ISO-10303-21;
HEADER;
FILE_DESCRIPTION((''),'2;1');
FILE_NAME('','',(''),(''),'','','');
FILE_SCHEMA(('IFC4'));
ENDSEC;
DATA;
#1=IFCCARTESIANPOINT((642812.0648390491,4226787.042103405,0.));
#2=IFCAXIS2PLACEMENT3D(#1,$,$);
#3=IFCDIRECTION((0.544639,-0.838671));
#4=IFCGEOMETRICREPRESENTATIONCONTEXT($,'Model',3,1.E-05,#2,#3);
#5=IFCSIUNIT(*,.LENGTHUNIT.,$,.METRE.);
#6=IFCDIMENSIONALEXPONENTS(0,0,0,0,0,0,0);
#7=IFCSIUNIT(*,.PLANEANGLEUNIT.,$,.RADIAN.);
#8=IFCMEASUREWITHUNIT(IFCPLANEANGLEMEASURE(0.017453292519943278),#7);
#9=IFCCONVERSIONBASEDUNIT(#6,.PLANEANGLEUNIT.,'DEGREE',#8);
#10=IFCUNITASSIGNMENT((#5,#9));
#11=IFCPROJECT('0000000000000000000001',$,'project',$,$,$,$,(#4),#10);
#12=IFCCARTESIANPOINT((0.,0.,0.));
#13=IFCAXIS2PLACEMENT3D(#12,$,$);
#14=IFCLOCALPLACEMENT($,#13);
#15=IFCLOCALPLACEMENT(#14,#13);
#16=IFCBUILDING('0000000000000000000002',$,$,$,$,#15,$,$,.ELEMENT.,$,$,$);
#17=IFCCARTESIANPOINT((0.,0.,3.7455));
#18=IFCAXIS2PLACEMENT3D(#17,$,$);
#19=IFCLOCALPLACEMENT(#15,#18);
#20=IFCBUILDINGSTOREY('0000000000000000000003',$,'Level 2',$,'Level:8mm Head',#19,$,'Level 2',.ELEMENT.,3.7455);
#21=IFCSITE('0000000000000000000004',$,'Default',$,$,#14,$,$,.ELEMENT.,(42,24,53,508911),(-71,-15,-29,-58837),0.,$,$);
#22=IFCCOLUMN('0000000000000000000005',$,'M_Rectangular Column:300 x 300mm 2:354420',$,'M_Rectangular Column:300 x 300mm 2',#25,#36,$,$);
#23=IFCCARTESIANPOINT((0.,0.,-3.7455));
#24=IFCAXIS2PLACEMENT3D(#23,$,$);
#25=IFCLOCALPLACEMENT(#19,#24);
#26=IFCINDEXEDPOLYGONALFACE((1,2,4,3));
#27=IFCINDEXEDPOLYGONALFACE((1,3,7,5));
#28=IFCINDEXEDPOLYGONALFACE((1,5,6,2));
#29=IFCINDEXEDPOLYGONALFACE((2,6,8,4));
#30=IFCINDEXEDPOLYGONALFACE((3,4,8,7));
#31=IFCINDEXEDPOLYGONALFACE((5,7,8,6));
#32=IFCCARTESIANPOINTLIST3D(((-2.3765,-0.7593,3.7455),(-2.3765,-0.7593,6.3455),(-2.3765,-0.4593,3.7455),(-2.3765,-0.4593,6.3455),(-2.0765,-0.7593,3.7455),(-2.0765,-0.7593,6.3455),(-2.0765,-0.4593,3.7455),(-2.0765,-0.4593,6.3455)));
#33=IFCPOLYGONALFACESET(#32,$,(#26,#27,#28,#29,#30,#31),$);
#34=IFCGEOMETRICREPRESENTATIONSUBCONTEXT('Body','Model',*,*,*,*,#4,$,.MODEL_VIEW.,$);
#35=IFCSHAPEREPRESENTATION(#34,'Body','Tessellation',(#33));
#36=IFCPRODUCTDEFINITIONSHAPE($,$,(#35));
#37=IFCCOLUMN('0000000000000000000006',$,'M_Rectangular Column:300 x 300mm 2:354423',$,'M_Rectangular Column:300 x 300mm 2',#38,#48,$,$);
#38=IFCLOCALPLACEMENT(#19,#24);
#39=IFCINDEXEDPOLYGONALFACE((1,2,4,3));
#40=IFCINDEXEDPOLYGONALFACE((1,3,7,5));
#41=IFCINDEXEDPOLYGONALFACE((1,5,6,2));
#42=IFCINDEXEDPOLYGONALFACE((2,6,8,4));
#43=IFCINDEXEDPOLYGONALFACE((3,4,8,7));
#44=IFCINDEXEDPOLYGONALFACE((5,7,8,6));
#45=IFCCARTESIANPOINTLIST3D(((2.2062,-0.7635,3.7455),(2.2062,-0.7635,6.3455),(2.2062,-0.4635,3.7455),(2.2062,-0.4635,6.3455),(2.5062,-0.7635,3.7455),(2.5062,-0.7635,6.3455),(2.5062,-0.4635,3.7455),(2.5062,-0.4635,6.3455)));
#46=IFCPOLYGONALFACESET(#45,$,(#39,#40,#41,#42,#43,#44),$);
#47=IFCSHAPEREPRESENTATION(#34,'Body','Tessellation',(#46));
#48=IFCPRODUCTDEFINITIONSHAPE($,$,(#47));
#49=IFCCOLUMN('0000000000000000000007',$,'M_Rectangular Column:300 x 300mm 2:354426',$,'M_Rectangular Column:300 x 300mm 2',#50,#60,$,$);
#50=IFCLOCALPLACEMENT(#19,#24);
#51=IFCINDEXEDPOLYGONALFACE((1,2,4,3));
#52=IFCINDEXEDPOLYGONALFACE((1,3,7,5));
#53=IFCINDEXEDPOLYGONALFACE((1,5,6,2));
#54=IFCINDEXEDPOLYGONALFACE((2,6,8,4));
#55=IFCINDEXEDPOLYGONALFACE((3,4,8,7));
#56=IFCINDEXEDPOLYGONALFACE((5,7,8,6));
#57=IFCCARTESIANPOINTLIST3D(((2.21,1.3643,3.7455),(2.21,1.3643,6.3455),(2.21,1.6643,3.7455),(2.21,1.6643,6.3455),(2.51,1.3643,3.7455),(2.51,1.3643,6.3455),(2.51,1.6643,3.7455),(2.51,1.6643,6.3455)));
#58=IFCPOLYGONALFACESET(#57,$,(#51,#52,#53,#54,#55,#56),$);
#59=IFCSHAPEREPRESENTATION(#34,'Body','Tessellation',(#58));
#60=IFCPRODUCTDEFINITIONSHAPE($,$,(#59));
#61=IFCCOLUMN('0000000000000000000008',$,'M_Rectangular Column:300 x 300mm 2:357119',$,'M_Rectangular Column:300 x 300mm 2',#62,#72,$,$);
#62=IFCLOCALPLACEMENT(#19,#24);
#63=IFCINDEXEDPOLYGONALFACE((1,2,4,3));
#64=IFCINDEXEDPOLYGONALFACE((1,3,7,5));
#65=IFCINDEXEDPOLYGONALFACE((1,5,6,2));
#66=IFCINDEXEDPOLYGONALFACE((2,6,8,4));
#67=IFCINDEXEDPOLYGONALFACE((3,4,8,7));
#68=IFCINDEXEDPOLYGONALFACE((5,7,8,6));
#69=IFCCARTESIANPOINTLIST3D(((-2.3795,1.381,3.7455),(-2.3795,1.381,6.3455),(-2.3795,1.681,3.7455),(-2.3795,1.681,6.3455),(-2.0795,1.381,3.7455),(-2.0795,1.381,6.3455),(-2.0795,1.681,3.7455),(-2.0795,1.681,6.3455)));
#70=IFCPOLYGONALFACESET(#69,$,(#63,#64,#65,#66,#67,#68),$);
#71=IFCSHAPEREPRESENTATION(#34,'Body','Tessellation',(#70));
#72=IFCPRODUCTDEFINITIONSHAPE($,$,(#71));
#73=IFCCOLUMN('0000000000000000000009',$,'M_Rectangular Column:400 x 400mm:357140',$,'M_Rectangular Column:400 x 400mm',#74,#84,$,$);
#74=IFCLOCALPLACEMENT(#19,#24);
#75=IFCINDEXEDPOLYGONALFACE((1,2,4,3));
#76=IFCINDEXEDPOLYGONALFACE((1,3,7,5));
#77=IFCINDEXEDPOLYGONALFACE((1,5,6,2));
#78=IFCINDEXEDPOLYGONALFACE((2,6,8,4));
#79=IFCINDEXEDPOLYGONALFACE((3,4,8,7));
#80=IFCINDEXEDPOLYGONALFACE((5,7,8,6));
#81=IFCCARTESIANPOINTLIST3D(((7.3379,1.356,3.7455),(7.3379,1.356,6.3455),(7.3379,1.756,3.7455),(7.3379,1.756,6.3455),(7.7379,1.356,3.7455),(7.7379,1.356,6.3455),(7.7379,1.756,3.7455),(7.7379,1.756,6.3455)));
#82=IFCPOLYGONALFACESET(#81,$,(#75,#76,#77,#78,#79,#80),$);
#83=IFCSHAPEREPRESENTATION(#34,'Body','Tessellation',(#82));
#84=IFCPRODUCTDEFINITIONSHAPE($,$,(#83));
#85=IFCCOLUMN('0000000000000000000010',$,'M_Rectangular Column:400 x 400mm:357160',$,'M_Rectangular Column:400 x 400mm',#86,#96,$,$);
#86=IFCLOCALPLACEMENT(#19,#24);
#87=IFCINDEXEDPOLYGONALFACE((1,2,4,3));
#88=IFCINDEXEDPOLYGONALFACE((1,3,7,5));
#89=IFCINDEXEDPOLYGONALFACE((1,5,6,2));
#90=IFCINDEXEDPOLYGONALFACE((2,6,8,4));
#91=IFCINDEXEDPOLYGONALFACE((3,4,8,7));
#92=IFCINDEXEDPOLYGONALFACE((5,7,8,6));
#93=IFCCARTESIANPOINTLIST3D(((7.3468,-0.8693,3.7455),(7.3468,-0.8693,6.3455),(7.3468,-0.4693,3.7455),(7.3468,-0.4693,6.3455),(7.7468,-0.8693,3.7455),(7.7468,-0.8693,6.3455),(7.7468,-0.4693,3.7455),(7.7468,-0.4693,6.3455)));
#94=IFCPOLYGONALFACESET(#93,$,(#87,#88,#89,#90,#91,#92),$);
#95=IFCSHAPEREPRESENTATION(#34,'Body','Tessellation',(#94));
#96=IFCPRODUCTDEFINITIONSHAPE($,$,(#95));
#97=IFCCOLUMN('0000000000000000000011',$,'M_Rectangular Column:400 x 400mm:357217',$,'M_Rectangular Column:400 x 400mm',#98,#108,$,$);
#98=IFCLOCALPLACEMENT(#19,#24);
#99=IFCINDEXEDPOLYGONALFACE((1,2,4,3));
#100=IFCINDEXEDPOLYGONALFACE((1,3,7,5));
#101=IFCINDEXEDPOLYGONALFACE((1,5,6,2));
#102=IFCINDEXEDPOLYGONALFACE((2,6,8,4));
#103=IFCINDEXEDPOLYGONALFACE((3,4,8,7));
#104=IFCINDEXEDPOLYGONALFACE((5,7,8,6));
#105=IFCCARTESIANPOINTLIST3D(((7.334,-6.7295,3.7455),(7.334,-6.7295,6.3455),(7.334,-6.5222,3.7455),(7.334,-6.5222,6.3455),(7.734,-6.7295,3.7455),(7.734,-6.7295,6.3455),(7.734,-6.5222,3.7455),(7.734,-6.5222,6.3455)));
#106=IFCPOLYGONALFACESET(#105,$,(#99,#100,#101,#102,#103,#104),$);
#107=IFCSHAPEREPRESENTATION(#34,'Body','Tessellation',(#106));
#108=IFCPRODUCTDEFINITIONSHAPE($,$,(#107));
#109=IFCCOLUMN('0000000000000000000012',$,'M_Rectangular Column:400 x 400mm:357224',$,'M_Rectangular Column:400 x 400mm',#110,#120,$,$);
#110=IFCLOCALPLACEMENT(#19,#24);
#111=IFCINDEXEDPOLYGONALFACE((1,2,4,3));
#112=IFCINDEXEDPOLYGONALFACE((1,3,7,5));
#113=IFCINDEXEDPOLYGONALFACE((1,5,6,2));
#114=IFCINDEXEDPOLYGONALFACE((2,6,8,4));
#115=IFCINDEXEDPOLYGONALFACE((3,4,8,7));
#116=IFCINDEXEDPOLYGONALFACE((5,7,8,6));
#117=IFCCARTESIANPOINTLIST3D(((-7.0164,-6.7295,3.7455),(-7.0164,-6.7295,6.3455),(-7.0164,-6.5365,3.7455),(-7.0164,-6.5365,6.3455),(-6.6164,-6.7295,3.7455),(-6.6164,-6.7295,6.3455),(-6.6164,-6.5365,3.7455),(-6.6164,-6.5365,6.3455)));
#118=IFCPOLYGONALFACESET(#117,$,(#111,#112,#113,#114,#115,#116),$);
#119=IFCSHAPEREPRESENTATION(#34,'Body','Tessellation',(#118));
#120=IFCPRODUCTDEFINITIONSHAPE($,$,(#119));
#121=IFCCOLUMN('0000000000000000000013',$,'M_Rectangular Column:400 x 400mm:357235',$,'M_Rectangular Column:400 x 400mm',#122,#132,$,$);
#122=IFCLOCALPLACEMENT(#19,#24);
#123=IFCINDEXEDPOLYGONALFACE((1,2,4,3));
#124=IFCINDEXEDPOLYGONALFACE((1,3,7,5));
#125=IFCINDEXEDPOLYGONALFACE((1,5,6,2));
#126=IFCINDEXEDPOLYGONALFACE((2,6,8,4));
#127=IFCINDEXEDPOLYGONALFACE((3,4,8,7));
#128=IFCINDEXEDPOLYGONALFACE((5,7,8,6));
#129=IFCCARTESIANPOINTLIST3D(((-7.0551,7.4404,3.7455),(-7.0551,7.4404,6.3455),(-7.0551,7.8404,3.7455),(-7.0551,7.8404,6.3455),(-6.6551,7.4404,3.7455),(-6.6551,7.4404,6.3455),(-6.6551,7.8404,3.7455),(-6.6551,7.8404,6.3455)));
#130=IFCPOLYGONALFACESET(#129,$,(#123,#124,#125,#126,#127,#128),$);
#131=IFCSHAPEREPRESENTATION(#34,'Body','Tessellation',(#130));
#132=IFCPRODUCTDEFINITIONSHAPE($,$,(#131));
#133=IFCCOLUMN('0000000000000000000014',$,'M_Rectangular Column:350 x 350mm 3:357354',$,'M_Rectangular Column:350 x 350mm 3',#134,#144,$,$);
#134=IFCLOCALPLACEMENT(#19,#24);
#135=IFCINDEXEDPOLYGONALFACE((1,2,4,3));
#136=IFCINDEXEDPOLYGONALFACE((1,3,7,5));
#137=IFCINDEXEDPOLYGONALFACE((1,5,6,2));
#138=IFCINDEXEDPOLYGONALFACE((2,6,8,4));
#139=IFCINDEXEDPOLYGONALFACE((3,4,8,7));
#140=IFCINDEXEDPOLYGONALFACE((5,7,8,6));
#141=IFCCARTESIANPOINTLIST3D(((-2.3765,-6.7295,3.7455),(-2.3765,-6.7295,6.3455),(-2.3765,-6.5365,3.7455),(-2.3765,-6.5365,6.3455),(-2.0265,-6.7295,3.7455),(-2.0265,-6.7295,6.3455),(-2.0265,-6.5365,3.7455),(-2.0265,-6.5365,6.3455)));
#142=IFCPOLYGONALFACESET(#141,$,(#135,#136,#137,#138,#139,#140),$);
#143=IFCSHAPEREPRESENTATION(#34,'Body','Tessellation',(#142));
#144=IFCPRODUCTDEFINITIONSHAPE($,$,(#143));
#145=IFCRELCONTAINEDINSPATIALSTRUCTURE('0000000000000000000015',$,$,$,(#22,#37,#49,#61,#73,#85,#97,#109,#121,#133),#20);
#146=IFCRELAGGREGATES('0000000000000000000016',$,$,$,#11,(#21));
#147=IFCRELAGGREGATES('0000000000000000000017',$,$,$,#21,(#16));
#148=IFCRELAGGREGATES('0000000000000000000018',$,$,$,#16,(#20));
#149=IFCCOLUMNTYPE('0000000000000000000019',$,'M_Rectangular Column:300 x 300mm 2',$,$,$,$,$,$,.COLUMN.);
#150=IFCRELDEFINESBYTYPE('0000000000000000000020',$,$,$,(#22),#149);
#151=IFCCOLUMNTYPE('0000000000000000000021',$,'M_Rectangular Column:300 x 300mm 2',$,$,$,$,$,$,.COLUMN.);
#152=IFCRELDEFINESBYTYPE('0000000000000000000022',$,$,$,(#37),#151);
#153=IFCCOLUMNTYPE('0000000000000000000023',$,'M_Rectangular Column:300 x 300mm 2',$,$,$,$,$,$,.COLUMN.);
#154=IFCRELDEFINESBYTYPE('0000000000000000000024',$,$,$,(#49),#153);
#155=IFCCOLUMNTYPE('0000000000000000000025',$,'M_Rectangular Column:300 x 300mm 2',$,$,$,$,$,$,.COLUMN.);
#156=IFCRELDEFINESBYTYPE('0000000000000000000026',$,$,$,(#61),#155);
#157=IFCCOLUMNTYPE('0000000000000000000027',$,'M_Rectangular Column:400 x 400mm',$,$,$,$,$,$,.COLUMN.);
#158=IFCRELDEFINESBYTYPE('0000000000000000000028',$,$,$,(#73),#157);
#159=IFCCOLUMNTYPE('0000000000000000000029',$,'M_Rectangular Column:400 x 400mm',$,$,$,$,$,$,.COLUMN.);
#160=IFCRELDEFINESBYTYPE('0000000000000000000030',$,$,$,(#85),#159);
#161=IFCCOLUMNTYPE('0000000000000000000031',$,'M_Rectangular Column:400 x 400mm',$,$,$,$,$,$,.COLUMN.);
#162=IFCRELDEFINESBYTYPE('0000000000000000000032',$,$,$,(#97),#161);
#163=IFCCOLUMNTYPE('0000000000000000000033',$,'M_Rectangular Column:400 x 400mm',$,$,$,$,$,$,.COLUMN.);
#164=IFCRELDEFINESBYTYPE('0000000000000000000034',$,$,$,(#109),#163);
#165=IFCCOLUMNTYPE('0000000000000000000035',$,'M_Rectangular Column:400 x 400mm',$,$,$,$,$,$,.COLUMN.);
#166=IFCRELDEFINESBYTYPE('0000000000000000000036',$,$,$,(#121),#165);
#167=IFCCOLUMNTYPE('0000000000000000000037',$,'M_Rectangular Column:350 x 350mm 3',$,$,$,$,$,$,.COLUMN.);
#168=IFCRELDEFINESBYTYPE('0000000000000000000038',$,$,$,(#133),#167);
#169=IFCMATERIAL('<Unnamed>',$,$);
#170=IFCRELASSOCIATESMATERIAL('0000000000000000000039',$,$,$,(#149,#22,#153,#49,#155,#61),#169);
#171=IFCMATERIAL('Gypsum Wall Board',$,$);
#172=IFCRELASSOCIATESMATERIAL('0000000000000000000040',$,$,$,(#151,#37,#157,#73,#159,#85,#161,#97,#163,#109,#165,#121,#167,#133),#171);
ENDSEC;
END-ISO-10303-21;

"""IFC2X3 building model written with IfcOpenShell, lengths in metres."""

from ifc_helpers import new_model, entity, si_unit, converted_unit, direction, frame, frame_2d, origin, origin_2d_with_axis, place, context, subcontext, project, spatial, rectangle, extrude, source, transform, mapped, material, type_object, type_shapes, element, save


model = new_model("IFC2X3")

# Units and contexts
model_context = context("Model", 3, precision=1e-05, world=frame((642812.0648390491, 4226787.042103405, 0.0)), true_north=direction((0.544639, -0.838671)))
body_context = subcontext(model_context, "Body", "Model", "MODEL_VIEW")
ifc_project = project(units=[si_unit("LENGTHUNIT", "METRE"), converted_unit("PLANEANGLEUNIT", "DEGREE", entity("IfcPlaneAngleMeasure", 0.017453292519943278), si_unit("PLANEANGLEUNIT", "RADIAN"), dimensions=[0, 0, 0, 0, 0, 0, 0])], contexts=[model_context])

# Site, building, storey
site_placement = place(None, origin())
site = spatial("IfcSite", under=ifc_project, at=site_placement, Name="Default", CompositionType="ELEMENT", RefLatitude=(42, 24, 53, 508911), RefLongitude=(-71, -15, -29, -58837), RefElevation=0.0)
building_placement = place(site_placement, origin())
building = spatial("IfcBuilding", under=site, at=building_placement, CompositionType="ELEMENT")
storey_placement = place(building_placement, frame((0.0, 0.0, 3.7455)))
storey = spatial("IfcBuildingStorey", under=building, at=storey_placement, Name="Level 2", ObjectType="Level:8mm Head", LongName="Level 2", CompositionType="ELEMENT", Elevation=3.7455)

# Columns
ifc_material_1 = material(Name="<Unnamed>")
column_type_1 = type_object("IfcColumnType", Name="M_Rectangular Column:300 x 300mm 2", PredefinedType="COLUMN", material=ifc_material_1)
shared_shape_1 = source(origin(), body_context, "Body", "SweptSolid", [
    extrude(rectangle(XDim=0.3, YDim=0.3, at=frame_2d((0.0, 0.0), x_axis=(1.0, 0.0))), frame((-2.2265, -0.6093, 3.7455), z_axis=(0.0, 0.0, 1.0), x_axis=(-1.0, 0.0, 0.0)), (0.0, 0.0, 1.0), 2.6),
])
type_shapes(column_type_1, [shared_shape_1])
column_1_placement = place(storey_placement, frame((0.0, 0.0, -3.7455)))
element("IfcColumn", 1, at=column_1_placement, inside=storey, type_object=column_type_1, material=ifc_material_1, Name="M_Rectangular Column:300 x 300mm 2:354420", ObjectType="M_Rectangular Column:300 x 300mm 2", context=body_context, shape_type="MappedRepresentation", body=[
    mapped(shared_shape_1, transform((0.0, 0.0, 0.0), scale=1.0)),
])
ifc_material_2 = material(Name="Gypsum Wall Board")
column_type_2 = type_object("IfcColumnType", Name="M_Rectangular Column:300 x 300mm 2", PredefinedType="COLUMN", material=ifc_material_2)
shared_shape_2 = source(origin(), body_context, "Body", "SweptSolid", [
    extrude(rectangle(XDim=0.3, YDim=0.3, at=frame_2d((0.0, 0.0), x_axis=(1.0, 0.0))), frame((2.3562, -0.6135, 3.7455), z_axis=(0.0, 0.0, 1.0), x_axis=(0.0, -1.0, 0.0)), (0.0, 0.0, 1.0), 2.6),
])
type_shapes(column_type_2, [shared_shape_2])
column_2_placement = place(storey_placement, frame((0.0, 0.0, -3.7455)))
element("IfcColumn", 2, at=column_2_placement, inside=storey, type_object=column_type_2, material=ifc_material_2, Name="M_Rectangular Column:300 x 300mm 2:354423", ObjectType="M_Rectangular Column:300 x 300mm 2", context=body_context, shape_type="MappedRepresentation", body=[
    mapped(shared_shape_2, transform((0.0, 0.0, 0.0), scale=1.0)),
])
column_type_3 = type_object("IfcColumnType", Name="M_Rectangular Column:300 x 300mm 2", PredefinedType="COLUMN", material=ifc_material_1)
shared_shape_3 = source(origin(), body_context, "Body", "SweptSolid", [
    extrude(rectangle(XDim=0.3, YDim=0.3, at=frame_2d((0.0, 0.0), x_axis=(1.0, 0.0))), frame((2.36, 1.5143, 3.7455), z_axis=(0.0, 0.0, 1.0), x_axis=(-1.0, 0.0, 0.0)), (0.0, 0.0, 1.0), 2.6),
])
type_shapes(column_type_3, [shared_shape_3])
column_3_placement = place(storey_placement, frame((0.0, 0.0, -3.7455)))
element("IfcColumn", 3, at=column_3_placement, inside=storey, type_object=column_type_3, material=ifc_material_1, Name="M_Rectangular Column:300 x 300mm 2:354426", ObjectType="M_Rectangular Column:300 x 300mm 2", context=body_context, shape_type="MappedRepresentation", body=[
    mapped(shared_shape_3, transform((0.0, 0.0, 0.0), scale=1.0)),
])
column_type_4 = type_object("IfcColumnType", Name="M_Rectangular Column:300 x 300mm 2", PredefinedType="COLUMN", material=ifc_material_1)
shared_shape_4 = source(origin(), body_context, "Body", "SweptSolid", [
    extrude(rectangle(XDim=0.3, YDim=0.3, at=frame_2d((0.0, 0.0), x_axis=(1.0, 0.0))), frame((-2.2295, 1.531, 3.7455), z_axis=(0.0, 0.0, 1.0), x_axis=(-1.0, 0.0, 0.0)), (0.0, 0.0, 1.0), 2.6),
])
type_shapes(column_type_4, [shared_shape_4])
column_4_placement = place(storey_placement, frame((0.0, 0.0, -3.7455)))
element("IfcColumn", 4, at=column_4_placement, inside=storey, type_object=column_type_4, material=ifc_material_1, Name="M_Rectangular Column:300 x 300mm 2:357119", ObjectType="M_Rectangular Column:300 x 300mm 2", context=body_context, shape_type="MappedRepresentation", body=[
    mapped(shared_shape_4, transform((0.0, 0.0, 0.0), scale=1.0)),
])
column_type_5 = type_object("IfcColumnType", Name="M_Rectangular Column:400 x 400mm", PredefinedType="COLUMN", material=ifc_material_2)
shared_shape_5 = source(origin(), body_context, "Body", "SweptSolid", [
    extrude(rectangle(XDim=0.4, YDim=0.4, at=origin_2d_with_axis()), frame((7.5379, 1.556, 3.7455), z_axis=(0.0, 0.0, 1.0), x_axis=(-1.0, 0.0, 0.0)), (0.0, 0.0, 1.0), 2.6),
])
type_shapes(column_type_5, [shared_shape_5])
column_5_placement = place(storey_placement, frame((0.0, 0.0, -3.7455)))
element("IfcColumn", 5, at=column_5_placement, inside=storey, type_object=column_type_5, material=ifc_material_2, Name="M_Rectangular Column:400 x 400mm:357140", ObjectType="M_Rectangular Column:400 x 400mm", context=body_context, shape_type="MappedRepresentation", body=[
    mapped(shared_shape_5, transform((0.0, 0.0, 0.0), scale=1.0)),
])
column_type_6 = type_object("IfcColumnType", Name="M_Rectangular Column:400 x 400mm", PredefinedType="COLUMN", material=ifc_material_2)
shared_shape_6 = source(origin(), body_context, "Body", "SweptSolid", [
    extrude(rectangle(XDim=0.4, YDim=0.4, at=frame_2d((0.0, 0.0), x_axis=(1.0, 0.0))), frame((7.5468, -0.6693, 3.7455), z_axis=(0.0, 0.0, 1.0), x_axis=(0.0, -1.0, 0.0)), (0.0, 0.0, 1.0), 2.6),
])
type_shapes(column_type_6, [shared_shape_6])
column_6_placement = place(storey_placement, frame((0.0, 0.0, -3.7455)))
element("IfcColumn", 6, at=column_6_placement, inside=storey, type_object=column_type_6, material=ifc_material_2, Name="M_Rectangular Column:400 x 400mm:357160", ObjectType="M_Rectangular Column:400 x 400mm", context=body_context, shape_type="MappedRepresentation", body=[
    mapped(shared_shape_6, transform((0.0, 0.0, 0.0), scale=1.0)),
])
column_type_7 = type_object("IfcColumnType", Name="M_Rectangular Column:400 x 400mm", PredefinedType="COLUMN", material=ifc_material_2)
shared_shape_7 = source(origin(), body_context, "Body", "SweptSolid", [
    extrude(rectangle(XDim=0.2073, YDim=0.4, at=frame_2d((0.0, 0.0), x_axis=(1.0, 0.0))), frame((7.534, -6.6258, 3.7455), z_axis=(0.0, 0.0, 1.0), x_axis=(0.0, -1.0, 0.0)), (0.0, 0.0, 1.0), 2.6),
])
type_shapes(column_type_7, [shared_shape_7])
column_7_placement = place(storey_placement, frame((0.0, 0.0, -3.7455)))
element("IfcColumn", 7, at=column_7_placement, inside=storey, type_object=column_type_7, material=ifc_material_2, Name="M_Rectangular Column:400 x 400mm:357217", ObjectType="M_Rectangular Column:400 x 400mm", context=body_context, shape_type="MappedRepresentation", body=[
    mapped(shared_shape_7, transform((0.0, 0.0, 0.0), scale=1.0)),
])
column_type_8 = type_object("IfcColumnType", Name="M_Rectangular Column:400 x 400mm", PredefinedType="COLUMN", material=ifc_material_2)
shared_shape_8 = source(origin(), body_context, "Body", "SweptSolid", [
    extrude(rectangle(XDim=0.193, YDim=0.4, at=origin_2d_with_axis()), frame((-6.8164, -6.633, 3.7455), z_axis=(0.0, 0.0, 1.0), x_axis=(0.0, -1.0, 0.0)), (0.0, 0.0, 1.0), 2.6),
])
type_shapes(column_type_8, [shared_shape_8])
column_8_placement = place(storey_placement, frame((0.0, 0.0, -3.7455)))
element("IfcColumn", 8, at=column_8_placement, inside=storey, type_object=column_type_8, material=ifc_material_2, Name="M_Rectangular Column:400 x 400mm:357224", ObjectType="M_Rectangular Column:400 x 400mm", context=body_context, shape_type="MappedRepresentation", body=[
    mapped(shared_shape_8, transform((0.0, 0.0, 0.0), scale=1.0)),
])
column_type_9 = type_object("IfcColumnType", Name="M_Rectangular Column:400 x 400mm", PredefinedType="COLUMN", material=ifc_material_2)
shared_shape_9 = source(origin(), body_context, "Body", "SweptSolid", [
    extrude(rectangle(XDim=0.4, YDim=0.4, at=frame_2d((0.0, 0.0), x_axis=(1.0, 0.0))), frame((-6.8551, 7.6404, 3.7455), z_axis=(0.0, 0.0, 1.0), x_axis=(-1.0, 0.0, 0.0)), (0.0, 0.0, 1.0), 2.6),
])
type_shapes(column_type_9, [shared_shape_9])
column_9_placement = place(storey_placement, frame((0.0, 0.0, -3.7455)))
element("IfcColumn", 9, at=column_9_placement, inside=storey, type_object=column_type_9, material=ifc_material_2, Name="M_Rectangular Column:400 x 400mm:357235", ObjectType="M_Rectangular Column:400 x 400mm", context=body_context, shape_type="MappedRepresentation", body=[
    mapped(shared_shape_9, transform((0.0, 0.0, 0.0), scale=1.0)),
])
column_type_10 = type_object("IfcColumnType", Name="M_Rectangular Column:350 x 350mm 3", PredefinedType="COLUMN", material=ifc_material_2)
shared_shape_10 = source(origin(), body_context, "Body", "SweptSolid", [
    extrude(rectangle(XDim=0.193, YDim=0.35, at=frame_2d((0.0, 0.0), x_axis=(1.0, 0.0))), frame((-2.2015, -6.633, 3.7455), z_axis=(0.0, 0.0, 1.0), x_axis=(0.0, -1.0, 0.0)), (0.0, 0.0, 1.0), 2.6),
])
type_shapes(column_type_10, [shared_shape_10])
column_10_placement = place(storey_placement, frame((0.0, 0.0, -3.7455)))
element("IfcColumn", 10, at=column_10_placement, inside=storey, type_object=column_type_10, material=ifc_material_2, Name="M_Rectangular Column:350 x 350mm 3:357354", ObjectType="M_Rectangular Column:350 x 350mm 3", context=body_context, shape_type="MappedRepresentation", body=[
    mapped(shared_shape_10, transform((0.0, 0.0, 0.0), scale=1.0)),
])

save(model, "model.ifc")
